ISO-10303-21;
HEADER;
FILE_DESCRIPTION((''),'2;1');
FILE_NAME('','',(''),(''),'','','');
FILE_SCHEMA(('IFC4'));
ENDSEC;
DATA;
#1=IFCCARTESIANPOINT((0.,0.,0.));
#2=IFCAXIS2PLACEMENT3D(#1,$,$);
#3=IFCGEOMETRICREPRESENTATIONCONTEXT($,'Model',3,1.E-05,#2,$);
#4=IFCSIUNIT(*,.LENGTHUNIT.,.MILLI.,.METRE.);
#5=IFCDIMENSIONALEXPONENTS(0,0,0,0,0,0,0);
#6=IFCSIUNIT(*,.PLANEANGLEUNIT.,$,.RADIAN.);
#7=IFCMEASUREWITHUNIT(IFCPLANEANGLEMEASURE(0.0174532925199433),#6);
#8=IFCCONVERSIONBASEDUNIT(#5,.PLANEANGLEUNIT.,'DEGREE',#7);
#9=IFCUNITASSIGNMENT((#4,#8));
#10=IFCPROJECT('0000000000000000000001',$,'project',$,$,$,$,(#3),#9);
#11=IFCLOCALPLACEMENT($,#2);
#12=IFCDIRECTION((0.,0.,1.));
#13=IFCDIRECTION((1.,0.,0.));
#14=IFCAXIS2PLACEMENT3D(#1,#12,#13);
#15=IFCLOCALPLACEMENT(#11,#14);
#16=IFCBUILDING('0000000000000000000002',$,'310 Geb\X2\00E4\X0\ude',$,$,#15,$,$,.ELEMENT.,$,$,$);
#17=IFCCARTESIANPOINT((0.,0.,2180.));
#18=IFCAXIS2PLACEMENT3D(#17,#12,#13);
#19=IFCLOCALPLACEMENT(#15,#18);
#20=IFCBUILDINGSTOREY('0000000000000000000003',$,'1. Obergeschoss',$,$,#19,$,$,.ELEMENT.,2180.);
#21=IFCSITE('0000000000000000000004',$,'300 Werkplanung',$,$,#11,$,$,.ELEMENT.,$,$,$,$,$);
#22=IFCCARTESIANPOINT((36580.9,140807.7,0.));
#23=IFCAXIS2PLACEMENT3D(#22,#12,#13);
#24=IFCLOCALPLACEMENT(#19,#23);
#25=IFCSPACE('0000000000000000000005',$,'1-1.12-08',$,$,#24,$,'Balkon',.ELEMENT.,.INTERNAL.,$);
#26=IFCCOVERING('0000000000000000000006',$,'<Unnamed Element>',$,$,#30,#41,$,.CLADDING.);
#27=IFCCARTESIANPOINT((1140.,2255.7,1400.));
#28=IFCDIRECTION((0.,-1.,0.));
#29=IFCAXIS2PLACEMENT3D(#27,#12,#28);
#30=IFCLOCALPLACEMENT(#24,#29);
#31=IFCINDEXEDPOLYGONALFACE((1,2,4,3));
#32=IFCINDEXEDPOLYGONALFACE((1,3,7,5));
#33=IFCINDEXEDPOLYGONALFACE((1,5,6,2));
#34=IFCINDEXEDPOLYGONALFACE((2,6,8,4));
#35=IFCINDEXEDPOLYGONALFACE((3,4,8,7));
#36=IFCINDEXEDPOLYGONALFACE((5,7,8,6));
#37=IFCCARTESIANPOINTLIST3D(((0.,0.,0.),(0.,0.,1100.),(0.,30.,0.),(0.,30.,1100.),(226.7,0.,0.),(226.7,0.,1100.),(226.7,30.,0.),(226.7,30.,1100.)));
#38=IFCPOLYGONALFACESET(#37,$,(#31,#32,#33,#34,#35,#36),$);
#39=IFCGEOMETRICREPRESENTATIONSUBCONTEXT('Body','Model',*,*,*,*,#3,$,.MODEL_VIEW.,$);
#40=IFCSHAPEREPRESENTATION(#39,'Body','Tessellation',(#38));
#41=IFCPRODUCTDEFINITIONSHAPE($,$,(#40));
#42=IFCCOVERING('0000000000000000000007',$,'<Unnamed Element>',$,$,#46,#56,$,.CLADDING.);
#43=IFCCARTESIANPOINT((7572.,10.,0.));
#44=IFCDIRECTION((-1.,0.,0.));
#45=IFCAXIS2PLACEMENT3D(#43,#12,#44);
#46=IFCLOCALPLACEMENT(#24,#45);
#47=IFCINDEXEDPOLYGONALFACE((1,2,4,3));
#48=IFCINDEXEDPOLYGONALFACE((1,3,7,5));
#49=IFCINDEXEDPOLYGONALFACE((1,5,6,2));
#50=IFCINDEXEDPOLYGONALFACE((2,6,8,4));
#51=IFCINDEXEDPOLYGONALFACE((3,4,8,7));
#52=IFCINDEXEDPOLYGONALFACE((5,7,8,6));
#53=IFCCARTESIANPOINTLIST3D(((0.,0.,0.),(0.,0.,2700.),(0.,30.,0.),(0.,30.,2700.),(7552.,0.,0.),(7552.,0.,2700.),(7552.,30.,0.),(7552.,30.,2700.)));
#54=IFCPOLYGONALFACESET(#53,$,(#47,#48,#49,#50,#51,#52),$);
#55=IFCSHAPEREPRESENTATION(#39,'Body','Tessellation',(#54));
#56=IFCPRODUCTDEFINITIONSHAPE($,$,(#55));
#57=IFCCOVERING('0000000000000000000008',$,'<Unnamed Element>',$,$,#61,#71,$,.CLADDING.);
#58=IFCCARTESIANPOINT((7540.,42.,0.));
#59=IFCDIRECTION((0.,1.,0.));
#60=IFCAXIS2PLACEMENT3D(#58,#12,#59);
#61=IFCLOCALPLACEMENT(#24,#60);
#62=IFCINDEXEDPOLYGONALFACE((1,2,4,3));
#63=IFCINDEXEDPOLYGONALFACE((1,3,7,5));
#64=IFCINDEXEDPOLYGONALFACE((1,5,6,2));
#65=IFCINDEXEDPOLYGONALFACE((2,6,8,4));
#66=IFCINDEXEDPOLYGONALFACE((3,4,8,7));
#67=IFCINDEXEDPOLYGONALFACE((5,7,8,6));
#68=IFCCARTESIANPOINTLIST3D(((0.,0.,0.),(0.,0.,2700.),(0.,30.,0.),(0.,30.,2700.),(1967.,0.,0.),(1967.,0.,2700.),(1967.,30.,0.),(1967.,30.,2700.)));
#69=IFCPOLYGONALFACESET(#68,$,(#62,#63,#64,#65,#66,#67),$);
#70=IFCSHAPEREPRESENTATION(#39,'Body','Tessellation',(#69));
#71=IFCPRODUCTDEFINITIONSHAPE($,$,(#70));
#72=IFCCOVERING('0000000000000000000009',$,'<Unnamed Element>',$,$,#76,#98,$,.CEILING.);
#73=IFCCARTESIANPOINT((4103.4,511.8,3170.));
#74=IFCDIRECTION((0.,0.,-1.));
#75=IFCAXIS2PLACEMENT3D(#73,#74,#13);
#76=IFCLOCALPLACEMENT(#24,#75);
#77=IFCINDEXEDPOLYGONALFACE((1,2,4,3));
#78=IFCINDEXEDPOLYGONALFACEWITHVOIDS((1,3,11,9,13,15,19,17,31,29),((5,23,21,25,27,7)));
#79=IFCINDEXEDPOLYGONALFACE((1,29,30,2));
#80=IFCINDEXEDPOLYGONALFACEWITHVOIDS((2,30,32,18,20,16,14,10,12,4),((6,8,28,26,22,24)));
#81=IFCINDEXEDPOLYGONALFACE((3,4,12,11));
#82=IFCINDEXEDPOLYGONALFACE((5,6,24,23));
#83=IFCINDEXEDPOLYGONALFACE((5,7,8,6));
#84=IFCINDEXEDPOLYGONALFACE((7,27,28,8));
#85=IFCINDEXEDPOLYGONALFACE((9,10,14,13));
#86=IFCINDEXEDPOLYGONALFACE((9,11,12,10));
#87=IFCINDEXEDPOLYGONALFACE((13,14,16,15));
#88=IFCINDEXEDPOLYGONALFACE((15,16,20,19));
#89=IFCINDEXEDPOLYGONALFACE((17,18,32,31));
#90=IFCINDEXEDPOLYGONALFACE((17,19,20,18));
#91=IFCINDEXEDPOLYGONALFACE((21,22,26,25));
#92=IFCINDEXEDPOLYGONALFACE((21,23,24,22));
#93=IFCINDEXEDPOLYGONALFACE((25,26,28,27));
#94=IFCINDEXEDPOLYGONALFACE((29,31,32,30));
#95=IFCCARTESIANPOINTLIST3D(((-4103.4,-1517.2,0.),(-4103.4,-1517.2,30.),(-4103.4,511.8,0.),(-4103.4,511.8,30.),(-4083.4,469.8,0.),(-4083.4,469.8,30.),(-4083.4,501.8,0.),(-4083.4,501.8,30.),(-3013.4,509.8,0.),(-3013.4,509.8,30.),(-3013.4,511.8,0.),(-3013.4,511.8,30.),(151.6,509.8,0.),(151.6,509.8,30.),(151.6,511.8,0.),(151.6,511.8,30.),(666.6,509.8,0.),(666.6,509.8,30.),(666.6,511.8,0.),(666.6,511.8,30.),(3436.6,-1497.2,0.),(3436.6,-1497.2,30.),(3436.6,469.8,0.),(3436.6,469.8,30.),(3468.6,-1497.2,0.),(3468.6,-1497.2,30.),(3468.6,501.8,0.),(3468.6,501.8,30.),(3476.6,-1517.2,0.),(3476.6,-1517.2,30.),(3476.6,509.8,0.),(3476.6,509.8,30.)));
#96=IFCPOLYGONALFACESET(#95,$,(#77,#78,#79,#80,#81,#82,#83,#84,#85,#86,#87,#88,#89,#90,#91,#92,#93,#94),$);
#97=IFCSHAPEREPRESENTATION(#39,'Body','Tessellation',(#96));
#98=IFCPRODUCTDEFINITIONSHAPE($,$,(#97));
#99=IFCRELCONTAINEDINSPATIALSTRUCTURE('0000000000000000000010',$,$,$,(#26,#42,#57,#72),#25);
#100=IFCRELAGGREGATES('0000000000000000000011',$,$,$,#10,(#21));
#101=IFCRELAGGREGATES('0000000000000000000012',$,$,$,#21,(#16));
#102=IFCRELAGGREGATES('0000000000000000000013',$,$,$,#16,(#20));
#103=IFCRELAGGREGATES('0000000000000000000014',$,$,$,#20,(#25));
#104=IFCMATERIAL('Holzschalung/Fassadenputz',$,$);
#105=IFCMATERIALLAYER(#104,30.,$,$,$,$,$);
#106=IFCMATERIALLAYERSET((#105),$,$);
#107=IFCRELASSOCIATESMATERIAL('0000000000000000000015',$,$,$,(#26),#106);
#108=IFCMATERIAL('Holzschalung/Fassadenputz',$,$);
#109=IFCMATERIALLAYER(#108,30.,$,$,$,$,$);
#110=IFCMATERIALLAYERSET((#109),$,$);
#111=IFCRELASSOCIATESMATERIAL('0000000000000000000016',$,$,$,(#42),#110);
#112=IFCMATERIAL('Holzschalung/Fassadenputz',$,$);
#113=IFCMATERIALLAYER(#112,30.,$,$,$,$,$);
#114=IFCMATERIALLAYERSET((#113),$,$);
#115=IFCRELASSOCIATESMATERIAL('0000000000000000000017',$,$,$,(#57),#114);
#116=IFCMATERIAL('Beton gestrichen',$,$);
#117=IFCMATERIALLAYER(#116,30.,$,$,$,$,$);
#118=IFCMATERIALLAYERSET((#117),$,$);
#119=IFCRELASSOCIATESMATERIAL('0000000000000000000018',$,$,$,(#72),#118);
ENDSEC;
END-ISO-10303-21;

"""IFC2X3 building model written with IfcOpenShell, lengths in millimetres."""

from ifc_helpers import new_model, entity, si_unit, converted_unit, frame, frame_2d, origin, origin_with_axes, place, context, subcontext, project, spatial, polyline, rectangle, outline, extrude, material, layer, layer_set, layer_usage, element, save


model = new_model("IFC2X3")

# Units and contexts
model_context = context("Model", 3, precision=1e-05, world=origin())
body_context = subcontext(model_context, "Body", "Model", "MODEL_VIEW")
ifc_project = project(units=[si_unit("LENGTHUNIT", "METRE", prefix="MILLI"), converted_unit("PLANEANGLEUNIT", "DEGREE", entity("IfcPlaneAngleMeasure", 0.0174532925199433), si_unit("PLANEANGLEUNIT", "RADIAN"), dimensions=[0, 0, 0, 0, 0, 0, 0])], contexts=[model_context])

# Site, building, storey
site_placement = place(None, origin())
site = spatial("IfcSite", under=ifc_project, at=site_placement, Name="300 Werkplanung", CompositionType="ELEMENT")
building_placement = place(site_placement, origin_with_axes())
building = spatial("IfcBuilding", under=site, at=building_placement, Name="310 Gebäude", CompositionType="ELEMENT")
storey_placement = place(building_placement, frame((0.0, 0.0, 2180.0), z_axis=(0.0, 0.0, 1.0), x_axis=(1.0, 0.0, 0.0)))
storey = spatial("IfcBuildingStorey", under=building, at=storey_placement, Name="1. Obergeschoss", CompositionType="ELEMENT", Elevation=2180.0)

# Shared definitions
space_1_placement = place(storey_placement, frame((36580.9, 140807.7, 0.0), z_axis=(0.0, 0.0, 1.0), x_axis=(1.0, 0.0, 0.0)))
space_1 = spatial("IfcSpace", under=storey, at=space_1_placement, Name="1-1.12-08", LongName="Balkon", CompositionType="ELEMENT", InteriorOrExteriorSpace="INTERNAL")

# Coverings
ifc_material_1 = material(Name="Holzschalung/Fassadenputz")
ifc_layer_1 = layer(ifc_material_1, 30.0)
ifc_layer_set_1 = layer_set([ifc_layer_1])
ifc_layer_usage_1 = layer_usage(ifc_layer_set_1, "AXIS3", "POSITIVE", 0.0)
covering_1_placement = place(space_1_placement, frame((1140.0, 2255.7, 1400.0), z_axis=(0.0, 0.0, 1.0), x_axis=(0.0, -1.0, 0.0)))
element("IfcCovering", 1, at=covering_1_placement, inside=space_1, material=ifc_layer_usage_1, Name="<Unnamed Element>", PredefinedType="CLADDING", context=body_context, shape_type="SweptSolid", body=[
    extrude(rectangle(XDim=226.7, YDim=1100.0, at=frame_2d((-113.3, -550.0), x_axis=(-1.0, 0.0))), frame((226.7, 0.0, 0.0), z_axis=(0.0, 1.0, 0.0), x_axis=(1.0, 0.0, 0.0)), (0.0, 0.0, 1.0), 30.0),
])
ifc_material_2 = material(Name="Holzschalung/Fassadenputz")
ifc_layer_2 = layer(ifc_material_2, 30.0)
ifc_layer_set_2 = layer_set([ifc_layer_2])
ifc_layer_usage_2 = layer_usage(ifc_layer_set_2, "AXIS3", "POSITIVE", 0.0)
covering_2_placement = place(space_1_placement, frame((7572.0, 10.0, 0.0), z_axis=(0.0, 0.0, 1.0), x_axis=(-1.0, 0.0, 0.0)))
element("IfcCovering", 2, at=covering_2_placement, inside=space_1, material=ifc_layer_usage_2, Name="<Unnamed Element>", PredefinedType="CLADDING", context=body_context, shape_type="SweptSolid", body=[
    extrude(rectangle(XDim=7552.0, YDim=2700.0, at=frame_2d((-3776.0, -1350.0), x_axis=(-1.0, 0.0))), frame((7552.0, 0.0, 0.0), z_axis=(0.0, 1.0, 0.0), x_axis=(1.0, 0.0, 0.0)), (0.0, 0.0, 1.0), 30.0),
])
ifc_material_3 = material(Name="Holzschalung/Fassadenputz")
ifc_layer_3 = layer(ifc_material_3, 30.0)
ifc_layer_set_3 = layer_set([ifc_layer_3])
ifc_layer_usage_3 = layer_usage(ifc_layer_set_3, "AXIS3", "POSITIVE", 0.0)
covering_3_placement = place(space_1_placement, frame((7540.0, 42.0, 0.0), z_axis=(0.0, 0.0, 1.0), x_axis=(0.0, 1.0, 0.0)))
element("IfcCovering", 3, at=covering_3_placement, inside=space_1, material=ifc_layer_usage_3, Name="<Unnamed Element>", PredefinedType="CLADDING", context=body_context, shape_type="SweptSolid", body=[
    extrude(rectangle(XDim=1967.0, YDim=2700.0, at=frame_2d((-983.5, -1350.0), x_axis=(-1.0, 0.0))), frame((1967.0, 0.0, 0.0), z_axis=(0.0, 1.0, 0.0), x_axis=(1.0, 0.0, 0.0)), (0.0, 0.0, 1.0), 30.0),
])
ifc_material_4 = material(Name="Beton gestrichen")
ifc_layer_4 = layer(ifc_material_4, 30.0)
ifc_layer_set_4 = layer_set([ifc_layer_4])
ifc_layer_usage_4 = layer_usage(ifc_layer_set_4, "AXIS3", "POSITIVE", 0.0)
covering_4_placement = place(space_1_placement, frame((4103.4, 511.8, 3170.0), z_axis=(0.0, 0.0, -1.0), x_axis=(1.0, 0.0, 0.0)))
element("IfcCovering", 4, at=covering_4_placement, inside=space_1, material=ifc_layer_usage_4, Name="<Unnamed Element>", PredefinedType="CEILING", context=body_context, shape_type="SweptSolid", body=[
    extrude(outline(polyline([(-3013.4, 509.8), (-3013.4, 511.8), (-4103.4, 511.8), (-4103.4, -1517.2), (3476.6, -1517.2), (3476.6, 509.8), (666.6, 509.8), (666.6, 511.8), (151.6, 511.8), (151.6, 509.8), (-3013.4, 509.8)]), holes=[polyline([(3468.6, 501.8), (3468.6, -1497.2), (3436.6, -1497.2), (3436.6, 469.8), (-4083.4, 469.8), (-4083.4, 501.8), (3468.6, 501.8)])]), origin_with_axes(), (0.0, 0.0, 1.0), 30.0),
])

save(model, "model.ifc")
